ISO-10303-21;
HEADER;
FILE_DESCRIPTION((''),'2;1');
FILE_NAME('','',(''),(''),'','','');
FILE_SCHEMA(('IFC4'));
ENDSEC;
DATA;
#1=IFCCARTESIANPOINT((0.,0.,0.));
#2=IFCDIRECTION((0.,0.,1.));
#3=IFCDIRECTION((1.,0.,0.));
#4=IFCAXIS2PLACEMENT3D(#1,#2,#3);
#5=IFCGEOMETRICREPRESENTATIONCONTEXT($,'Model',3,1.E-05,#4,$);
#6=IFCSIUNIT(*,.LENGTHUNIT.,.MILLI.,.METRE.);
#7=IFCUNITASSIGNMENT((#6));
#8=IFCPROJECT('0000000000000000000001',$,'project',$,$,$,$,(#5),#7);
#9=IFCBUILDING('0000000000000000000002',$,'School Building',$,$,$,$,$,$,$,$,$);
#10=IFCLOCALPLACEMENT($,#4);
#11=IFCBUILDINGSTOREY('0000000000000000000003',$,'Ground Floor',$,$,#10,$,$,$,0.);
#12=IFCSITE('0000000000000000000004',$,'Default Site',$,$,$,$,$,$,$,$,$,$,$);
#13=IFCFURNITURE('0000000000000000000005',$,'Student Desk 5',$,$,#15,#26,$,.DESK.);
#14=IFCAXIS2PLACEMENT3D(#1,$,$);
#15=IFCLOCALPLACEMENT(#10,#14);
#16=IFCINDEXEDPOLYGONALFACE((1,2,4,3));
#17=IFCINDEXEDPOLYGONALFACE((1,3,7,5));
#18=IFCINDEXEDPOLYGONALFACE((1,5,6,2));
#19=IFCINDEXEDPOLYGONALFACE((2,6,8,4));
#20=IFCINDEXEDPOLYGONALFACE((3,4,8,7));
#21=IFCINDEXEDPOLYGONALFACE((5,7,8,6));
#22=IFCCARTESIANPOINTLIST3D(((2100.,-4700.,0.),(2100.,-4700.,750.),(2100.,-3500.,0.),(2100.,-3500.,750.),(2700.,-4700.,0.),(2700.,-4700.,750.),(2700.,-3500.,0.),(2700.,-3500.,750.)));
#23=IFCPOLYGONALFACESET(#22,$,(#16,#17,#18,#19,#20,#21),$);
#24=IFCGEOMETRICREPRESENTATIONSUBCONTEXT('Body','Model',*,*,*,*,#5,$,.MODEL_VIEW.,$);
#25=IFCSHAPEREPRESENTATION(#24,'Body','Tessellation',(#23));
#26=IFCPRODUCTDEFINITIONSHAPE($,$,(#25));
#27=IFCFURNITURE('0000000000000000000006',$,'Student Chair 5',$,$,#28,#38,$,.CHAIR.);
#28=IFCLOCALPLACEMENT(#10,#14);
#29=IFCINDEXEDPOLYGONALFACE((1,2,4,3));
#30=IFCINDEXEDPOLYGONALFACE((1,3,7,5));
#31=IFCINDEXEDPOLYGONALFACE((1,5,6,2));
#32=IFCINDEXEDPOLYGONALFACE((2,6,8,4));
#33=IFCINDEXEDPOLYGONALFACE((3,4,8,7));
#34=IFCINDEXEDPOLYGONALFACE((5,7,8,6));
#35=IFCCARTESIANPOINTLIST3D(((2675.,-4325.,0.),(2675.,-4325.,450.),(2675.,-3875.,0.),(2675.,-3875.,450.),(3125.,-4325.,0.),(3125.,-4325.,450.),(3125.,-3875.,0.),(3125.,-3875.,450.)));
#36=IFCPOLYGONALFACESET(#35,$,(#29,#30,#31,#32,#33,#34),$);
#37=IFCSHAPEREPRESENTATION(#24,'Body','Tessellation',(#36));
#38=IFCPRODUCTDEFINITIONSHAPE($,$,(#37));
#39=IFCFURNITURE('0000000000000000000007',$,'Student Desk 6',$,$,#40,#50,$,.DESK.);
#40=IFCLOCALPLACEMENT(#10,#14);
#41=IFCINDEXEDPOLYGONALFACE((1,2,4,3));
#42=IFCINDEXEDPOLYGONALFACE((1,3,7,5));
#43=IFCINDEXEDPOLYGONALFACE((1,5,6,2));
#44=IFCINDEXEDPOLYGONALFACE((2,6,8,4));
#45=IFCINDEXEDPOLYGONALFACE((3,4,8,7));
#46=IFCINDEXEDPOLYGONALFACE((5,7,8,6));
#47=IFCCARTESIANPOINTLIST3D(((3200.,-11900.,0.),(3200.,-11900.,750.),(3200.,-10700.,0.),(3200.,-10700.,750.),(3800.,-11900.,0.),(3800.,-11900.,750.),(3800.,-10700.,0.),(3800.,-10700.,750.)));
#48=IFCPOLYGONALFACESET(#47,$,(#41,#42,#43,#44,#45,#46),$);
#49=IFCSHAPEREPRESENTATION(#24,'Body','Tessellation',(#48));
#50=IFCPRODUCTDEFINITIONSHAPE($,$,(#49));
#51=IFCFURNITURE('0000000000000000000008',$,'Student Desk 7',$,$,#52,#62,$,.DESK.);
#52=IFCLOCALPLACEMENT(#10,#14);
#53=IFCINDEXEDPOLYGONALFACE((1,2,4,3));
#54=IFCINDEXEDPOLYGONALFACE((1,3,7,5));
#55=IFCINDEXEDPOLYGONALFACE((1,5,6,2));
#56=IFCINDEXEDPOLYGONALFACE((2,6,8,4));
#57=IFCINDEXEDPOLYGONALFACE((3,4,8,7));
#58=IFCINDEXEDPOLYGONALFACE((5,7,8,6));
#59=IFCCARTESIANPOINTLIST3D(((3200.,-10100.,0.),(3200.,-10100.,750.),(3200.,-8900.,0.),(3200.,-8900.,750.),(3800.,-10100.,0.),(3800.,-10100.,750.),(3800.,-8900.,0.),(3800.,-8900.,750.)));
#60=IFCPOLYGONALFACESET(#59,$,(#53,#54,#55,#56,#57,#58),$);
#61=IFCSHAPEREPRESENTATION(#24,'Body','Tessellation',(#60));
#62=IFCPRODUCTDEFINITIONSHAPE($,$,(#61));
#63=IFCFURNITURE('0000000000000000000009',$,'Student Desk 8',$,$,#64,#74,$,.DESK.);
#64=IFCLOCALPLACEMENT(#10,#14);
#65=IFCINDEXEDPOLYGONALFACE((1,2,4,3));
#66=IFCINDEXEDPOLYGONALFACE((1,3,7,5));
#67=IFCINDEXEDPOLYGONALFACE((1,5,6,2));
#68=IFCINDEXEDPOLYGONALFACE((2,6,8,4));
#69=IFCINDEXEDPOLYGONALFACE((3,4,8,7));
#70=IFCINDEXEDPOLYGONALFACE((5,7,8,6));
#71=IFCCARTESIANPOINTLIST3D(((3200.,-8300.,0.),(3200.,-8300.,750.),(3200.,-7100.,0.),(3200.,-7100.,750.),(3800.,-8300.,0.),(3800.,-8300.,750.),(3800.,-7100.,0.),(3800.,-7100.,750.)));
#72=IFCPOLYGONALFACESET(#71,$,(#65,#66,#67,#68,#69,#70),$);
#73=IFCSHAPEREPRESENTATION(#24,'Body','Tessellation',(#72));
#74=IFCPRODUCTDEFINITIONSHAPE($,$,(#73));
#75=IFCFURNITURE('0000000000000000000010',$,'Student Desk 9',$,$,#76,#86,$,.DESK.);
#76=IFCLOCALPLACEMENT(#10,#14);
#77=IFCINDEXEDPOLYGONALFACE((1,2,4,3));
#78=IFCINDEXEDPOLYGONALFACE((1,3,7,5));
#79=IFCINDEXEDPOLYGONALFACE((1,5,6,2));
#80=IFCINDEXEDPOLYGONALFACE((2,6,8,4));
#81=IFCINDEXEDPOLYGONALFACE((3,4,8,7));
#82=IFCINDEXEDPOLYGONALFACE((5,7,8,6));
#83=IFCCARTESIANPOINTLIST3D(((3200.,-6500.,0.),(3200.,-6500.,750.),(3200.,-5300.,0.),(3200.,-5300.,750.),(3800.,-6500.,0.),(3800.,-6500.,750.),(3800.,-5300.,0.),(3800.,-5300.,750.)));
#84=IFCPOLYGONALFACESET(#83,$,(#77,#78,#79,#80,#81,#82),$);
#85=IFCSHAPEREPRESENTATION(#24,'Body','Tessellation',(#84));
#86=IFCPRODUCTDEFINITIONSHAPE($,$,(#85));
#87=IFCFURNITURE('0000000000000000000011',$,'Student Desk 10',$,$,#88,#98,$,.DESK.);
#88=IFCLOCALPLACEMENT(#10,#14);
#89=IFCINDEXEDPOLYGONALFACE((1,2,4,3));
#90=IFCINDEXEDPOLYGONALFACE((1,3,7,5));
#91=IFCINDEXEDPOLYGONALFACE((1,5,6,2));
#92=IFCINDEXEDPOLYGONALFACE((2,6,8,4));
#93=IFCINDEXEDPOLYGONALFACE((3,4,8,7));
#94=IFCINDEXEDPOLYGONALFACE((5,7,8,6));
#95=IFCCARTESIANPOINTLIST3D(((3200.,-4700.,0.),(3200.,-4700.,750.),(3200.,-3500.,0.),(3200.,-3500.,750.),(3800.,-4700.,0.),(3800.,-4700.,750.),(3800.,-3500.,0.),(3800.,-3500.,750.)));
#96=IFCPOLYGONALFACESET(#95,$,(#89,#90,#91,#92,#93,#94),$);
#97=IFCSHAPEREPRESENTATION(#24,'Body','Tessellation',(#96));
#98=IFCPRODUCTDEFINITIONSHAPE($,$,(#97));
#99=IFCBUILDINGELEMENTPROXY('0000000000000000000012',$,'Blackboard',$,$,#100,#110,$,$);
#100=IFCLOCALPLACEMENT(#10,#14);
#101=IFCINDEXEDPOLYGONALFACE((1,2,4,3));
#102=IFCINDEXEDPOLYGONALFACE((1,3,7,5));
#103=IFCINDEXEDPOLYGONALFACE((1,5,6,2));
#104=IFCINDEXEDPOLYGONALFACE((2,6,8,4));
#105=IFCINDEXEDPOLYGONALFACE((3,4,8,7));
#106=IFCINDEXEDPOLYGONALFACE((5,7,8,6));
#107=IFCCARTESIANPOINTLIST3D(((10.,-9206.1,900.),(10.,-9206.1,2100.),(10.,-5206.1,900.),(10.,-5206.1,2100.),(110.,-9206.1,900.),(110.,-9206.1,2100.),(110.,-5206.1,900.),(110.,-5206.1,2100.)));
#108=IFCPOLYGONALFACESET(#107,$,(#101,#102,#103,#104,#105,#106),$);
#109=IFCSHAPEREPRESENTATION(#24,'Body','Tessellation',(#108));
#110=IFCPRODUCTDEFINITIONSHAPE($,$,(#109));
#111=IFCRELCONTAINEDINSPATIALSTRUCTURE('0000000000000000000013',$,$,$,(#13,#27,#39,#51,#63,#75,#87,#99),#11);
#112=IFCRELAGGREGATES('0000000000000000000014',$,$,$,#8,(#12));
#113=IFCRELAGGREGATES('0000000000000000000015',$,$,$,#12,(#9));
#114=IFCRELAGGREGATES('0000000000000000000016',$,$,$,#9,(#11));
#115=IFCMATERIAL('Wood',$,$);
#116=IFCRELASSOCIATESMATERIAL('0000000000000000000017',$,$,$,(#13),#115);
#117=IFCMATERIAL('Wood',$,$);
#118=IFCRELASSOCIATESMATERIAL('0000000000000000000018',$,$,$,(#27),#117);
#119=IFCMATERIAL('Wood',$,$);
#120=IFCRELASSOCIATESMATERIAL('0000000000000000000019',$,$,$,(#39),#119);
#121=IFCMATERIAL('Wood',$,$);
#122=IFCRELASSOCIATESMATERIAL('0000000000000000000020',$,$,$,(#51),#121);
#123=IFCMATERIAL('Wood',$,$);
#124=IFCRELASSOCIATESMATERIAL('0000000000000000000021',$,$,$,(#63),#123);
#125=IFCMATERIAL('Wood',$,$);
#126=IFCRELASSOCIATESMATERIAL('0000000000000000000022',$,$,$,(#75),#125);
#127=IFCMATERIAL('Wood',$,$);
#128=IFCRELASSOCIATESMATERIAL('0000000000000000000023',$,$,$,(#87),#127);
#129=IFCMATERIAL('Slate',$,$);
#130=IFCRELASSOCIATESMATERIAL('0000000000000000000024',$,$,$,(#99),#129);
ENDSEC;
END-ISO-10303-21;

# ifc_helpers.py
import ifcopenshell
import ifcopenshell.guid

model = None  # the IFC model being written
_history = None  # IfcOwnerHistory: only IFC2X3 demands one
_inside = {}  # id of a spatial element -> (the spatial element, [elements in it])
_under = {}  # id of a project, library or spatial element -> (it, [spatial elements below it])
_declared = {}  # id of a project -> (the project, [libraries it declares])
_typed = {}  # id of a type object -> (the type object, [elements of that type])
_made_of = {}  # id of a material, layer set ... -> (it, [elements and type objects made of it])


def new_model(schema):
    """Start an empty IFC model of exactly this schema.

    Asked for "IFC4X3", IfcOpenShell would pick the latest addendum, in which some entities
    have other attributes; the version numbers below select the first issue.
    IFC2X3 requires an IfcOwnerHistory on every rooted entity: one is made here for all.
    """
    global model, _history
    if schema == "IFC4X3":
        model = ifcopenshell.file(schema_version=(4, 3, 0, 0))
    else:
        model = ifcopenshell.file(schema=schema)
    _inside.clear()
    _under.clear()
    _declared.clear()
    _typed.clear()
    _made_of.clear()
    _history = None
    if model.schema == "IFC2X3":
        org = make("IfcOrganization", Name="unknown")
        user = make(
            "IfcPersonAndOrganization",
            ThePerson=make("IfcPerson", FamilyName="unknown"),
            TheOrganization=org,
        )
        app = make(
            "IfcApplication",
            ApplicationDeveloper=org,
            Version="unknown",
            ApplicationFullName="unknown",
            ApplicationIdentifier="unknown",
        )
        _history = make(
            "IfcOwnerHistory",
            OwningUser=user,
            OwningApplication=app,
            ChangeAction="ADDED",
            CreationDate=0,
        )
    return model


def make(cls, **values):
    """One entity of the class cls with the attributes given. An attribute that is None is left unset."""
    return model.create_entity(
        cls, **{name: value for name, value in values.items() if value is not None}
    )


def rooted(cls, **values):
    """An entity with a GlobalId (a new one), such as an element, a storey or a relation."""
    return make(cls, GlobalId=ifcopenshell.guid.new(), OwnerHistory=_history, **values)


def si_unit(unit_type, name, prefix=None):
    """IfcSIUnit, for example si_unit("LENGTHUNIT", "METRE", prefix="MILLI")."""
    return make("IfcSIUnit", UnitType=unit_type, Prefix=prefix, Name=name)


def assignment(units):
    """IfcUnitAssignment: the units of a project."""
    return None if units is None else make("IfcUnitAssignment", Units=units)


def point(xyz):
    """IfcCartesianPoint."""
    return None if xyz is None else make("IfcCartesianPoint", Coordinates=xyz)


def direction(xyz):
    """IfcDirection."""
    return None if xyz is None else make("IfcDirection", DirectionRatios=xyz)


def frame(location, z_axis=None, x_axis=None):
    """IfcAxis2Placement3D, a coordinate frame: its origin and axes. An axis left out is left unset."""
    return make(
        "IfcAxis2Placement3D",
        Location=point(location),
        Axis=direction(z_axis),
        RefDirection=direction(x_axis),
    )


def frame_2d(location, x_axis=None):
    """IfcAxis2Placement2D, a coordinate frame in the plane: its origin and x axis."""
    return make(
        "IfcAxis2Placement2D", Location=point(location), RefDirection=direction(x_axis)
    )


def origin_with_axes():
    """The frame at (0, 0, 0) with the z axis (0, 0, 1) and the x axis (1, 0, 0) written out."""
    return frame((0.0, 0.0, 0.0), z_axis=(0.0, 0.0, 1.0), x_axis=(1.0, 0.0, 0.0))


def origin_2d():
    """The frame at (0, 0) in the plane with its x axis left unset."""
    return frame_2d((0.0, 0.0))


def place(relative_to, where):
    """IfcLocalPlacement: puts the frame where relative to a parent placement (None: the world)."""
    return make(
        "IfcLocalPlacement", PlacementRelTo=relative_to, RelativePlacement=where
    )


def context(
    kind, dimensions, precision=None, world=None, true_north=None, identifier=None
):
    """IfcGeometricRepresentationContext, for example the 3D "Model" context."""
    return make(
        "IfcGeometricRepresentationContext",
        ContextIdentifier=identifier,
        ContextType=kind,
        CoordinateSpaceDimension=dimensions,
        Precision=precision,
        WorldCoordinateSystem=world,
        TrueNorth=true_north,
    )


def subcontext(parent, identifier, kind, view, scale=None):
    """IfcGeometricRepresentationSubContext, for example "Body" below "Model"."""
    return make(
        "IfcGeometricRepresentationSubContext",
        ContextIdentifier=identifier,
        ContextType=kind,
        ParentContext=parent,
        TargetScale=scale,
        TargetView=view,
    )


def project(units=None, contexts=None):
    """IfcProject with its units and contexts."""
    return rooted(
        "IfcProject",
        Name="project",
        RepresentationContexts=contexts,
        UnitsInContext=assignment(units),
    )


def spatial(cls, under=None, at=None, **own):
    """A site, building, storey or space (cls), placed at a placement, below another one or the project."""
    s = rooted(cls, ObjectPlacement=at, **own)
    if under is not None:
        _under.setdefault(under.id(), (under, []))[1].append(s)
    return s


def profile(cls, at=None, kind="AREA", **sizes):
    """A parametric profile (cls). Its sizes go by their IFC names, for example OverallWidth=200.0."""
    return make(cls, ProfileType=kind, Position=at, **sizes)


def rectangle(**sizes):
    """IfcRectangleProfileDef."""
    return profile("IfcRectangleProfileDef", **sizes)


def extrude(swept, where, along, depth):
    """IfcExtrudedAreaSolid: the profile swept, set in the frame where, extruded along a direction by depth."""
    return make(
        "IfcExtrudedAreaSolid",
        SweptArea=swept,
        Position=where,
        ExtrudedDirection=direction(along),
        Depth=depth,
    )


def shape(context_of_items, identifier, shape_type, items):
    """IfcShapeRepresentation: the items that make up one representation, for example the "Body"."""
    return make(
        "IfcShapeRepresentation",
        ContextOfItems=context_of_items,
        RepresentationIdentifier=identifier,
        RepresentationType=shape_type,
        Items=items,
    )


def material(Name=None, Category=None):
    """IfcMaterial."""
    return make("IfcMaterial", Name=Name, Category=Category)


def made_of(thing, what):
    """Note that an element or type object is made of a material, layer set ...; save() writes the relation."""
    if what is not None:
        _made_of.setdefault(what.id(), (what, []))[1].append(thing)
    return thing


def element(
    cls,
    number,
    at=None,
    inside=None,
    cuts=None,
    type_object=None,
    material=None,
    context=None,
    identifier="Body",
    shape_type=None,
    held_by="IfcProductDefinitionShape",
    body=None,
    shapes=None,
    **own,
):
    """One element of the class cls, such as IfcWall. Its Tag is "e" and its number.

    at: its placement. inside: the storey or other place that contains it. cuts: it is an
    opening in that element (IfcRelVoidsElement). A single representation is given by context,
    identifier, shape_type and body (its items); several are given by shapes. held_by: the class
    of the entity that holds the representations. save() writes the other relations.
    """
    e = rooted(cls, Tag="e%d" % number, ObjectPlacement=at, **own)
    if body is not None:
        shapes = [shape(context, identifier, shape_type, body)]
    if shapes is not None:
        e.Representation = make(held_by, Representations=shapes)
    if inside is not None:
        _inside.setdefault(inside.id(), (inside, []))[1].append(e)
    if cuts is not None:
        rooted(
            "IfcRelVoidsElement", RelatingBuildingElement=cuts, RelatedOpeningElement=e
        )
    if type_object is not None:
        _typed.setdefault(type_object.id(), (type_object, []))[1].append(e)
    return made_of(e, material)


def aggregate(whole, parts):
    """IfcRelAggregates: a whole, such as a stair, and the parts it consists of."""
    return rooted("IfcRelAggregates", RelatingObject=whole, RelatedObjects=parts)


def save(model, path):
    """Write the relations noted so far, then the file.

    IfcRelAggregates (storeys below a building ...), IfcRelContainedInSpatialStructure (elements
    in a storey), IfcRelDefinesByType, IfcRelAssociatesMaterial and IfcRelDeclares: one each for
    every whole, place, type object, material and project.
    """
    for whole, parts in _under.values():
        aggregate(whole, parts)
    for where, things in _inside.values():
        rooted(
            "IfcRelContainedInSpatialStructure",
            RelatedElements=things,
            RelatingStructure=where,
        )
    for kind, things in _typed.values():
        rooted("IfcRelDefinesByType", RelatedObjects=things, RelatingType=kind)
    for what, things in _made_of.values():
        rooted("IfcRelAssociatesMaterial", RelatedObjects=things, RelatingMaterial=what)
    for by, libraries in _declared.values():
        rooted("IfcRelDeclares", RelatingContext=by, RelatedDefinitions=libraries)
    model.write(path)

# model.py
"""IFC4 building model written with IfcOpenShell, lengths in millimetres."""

from ifc_helpers import new_model, si_unit, frame, origin_with_axes, origin_2d, place, context, subcontext, project, spatial, rectangle, extrude, material, element, save


model = new_model("IFC4")

# Units and contexts
model_context = context("Model", 3, precision=1e-05, world=origin_with_axes())
body_context = subcontext(model_context, "Body", "Model", "MODEL_VIEW")
ifc_project = project(units=[si_unit("LENGTHUNIT", "METRE", prefix="MILLI")], contexts=[model_context])

# Site, building, storey
site = spatial("IfcSite", under=ifc_project, Name="Default Site")
building = spatial("IfcBuilding", under=site, Name="School Building")
storey_placement = place(None, origin_with_axes())
storey = spatial("IfcBuildingStorey", under=building, at=storey_placement, Name="Ground Floor", Elevation=0.0)

# Furniture
ifc_material_1 = material(Name="Wood")
furniture_1_placement = place(storey_placement, frame((2400.0, -4100.0, 0.0), z_axis=(0.0, 0.0, 1.0), x_axis=(0.0, 1.0, 0.0)))
element("IfcFurniture", 1, at=furniture_1_placement, inside=storey, material=ifc_material_1, Name="Student Desk 5", PredefinedType="DESK", context=body_context, shape_type="SweptSolid", body=[
    extrude(rectangle(XDim=1200.0, YDim=600.0, at=origin_2d()), origin_with_axes(), (0.0, 0.0, 1.0), 750.0),
])
ifc_material_2 = material(Name="Wood")
furniture_2_placement = place(storey_placement, frame((2900.0, -4100.0, 0.0), z_axis=(0.0, 0.0, 1.0), x_axis=(1.0, 0.0, 0.0)))
element("IfcFurniture", 2, at=furniture_2_placement, inside=storey, material=ifc_material_2, Name="Student Chair 5", PredefinedType="CHAIR", context=body_context, shape_type="SweptSolid", body=[
    extrude(rectangle(XDim=450.0, YDim=450.0, at=origin_2d()), origin_with_axes(), (0.0, 0.0, 1.0), 450.0),
])
ifc_material_3 = material(Name="Wood")
furniture_3_placement = place(storey_placement, frame((3500.0, -11300.0, 0.0), z_axis=(0.0, 0.0, 1.0), x_axis=(0.0, 1.0, 0.0)))
element("IfcFurniture", 3, at=furniture_3_placement, inside=storey, material=ifc_material_3, Name="Student Desk 6", PredefinedType="DESK", context=body_context, shape_type="SweptSolid", body=[
    extrude(rectangle(XDim=1200.0, YDim=600.0, at=origin_2d()), origin_with_axes(), (0.0, 0.0, 1.0), 750.0),
])
ifc_material_4 = material(Name="Wood")
furniture_4_placement = place(storey_placement, frame((3500.0, -9500.0, 0.0), z_axis=(0.0, 0.0, 1.0), x_axis=(0.0, 1.0, 0.0)))
element("IfcFurniture", 4, at=furniture_4_placement, inside=storey, material=ifc_material_4, Name="Student Desk 7", PredefinedType="DESK", context=body_context, shape_type="SweptSolid", body=[
    extrude(rectangle(XDim=1200.0, YDim=600.0, at=origin_2d()), origin_with_axes(), (0.0, 0.0, 1.0), 750.0),
])
ifc_material_5 = material(Name="Wood")
furniture_5_placement = place(storey_placement, frame((3500.0, -7700.0, 0.0), z_axis=(0.0, 0.0, 1.0), x_axis=(0.0, 1.0, 0.0)))
element("IfcFurniture", 5, at=furniture_5_placement, inside=storey, material=ifc_material_5, Name="Student Desk 8", PredefinedType="DESK", context=body_context, shape_type="SweptSolid", body=[
    extrude(rectangle(XDim=1200.0, YDim=600.0, at=origin_2d()), origin_with_axes(), (0.0, 0.0, 1.0), 750.0),
])
ifc_material_6 = material(Name="Wood")
furniture_6_placement = place(storey_placement, frame((3500.0, -5900.0, 0.0), z_axis=(0.0, 0.0, 1.0), x_axis=(0.0, 1.0, 0.0)))
element("IfcFurniture", 6, at=furniture_6_placement, inside=storey, material=ifc_material_6, Name="Student Desk 9", PredefinedType="DESK", context=body_context, shape_type="SweptSolid", body=[
    extrude(rectangle(XDim=1200.0, YDim=600.0, at=origin_2d()), origin_with_axes(), (0.0, 0.0, 1.0), 750.0),
])
ifc_material_7 = material(Name="Wood")
furniture_7_placement = place(storey_placement, frame((3500.0, -4100.0, 0.0), z_axis=(0.0, 0.0, 1.0), x_axis=(0.0, 1.0, 0.0)))
element("IfcFurniture", 7, at=furniture_7_placement, inside=storey, material=ifc_material_7, Name="Student Desk 10", PredefinedType="DESK", context=body_context, shape_type="SweptSolid", body=[
    extrude(rectangle(XDim=1200.0, YDim=600.0, at=origin_2d()), origin_with_axes(), (0.0, 0.0, 1.0), 750.0),
])

# Building element proxy
ifc_material_8 = material(Name="Slate")
proxy_placement = place(storey_placement, frame((60.0, -7206.1, 900.0), z_axis=(0.0, 0.0, 1.0), x_axis=(1.0, 0.0, 0.0)))
element("IfcBuildingElementProxy", 8, at=proxy_placement, inside=storey, material=ifc_material_8, Name="Blackboard", context=body_context, shape_type="SweptSolid", body=[
    extrude(rectangle(XDim=100.0, YDim=4000.0, at=origin_2d()), origin_with_axes(), (0.0, 0.0, 1.0), 1200.0),
])

save(model, "model.ifc")
